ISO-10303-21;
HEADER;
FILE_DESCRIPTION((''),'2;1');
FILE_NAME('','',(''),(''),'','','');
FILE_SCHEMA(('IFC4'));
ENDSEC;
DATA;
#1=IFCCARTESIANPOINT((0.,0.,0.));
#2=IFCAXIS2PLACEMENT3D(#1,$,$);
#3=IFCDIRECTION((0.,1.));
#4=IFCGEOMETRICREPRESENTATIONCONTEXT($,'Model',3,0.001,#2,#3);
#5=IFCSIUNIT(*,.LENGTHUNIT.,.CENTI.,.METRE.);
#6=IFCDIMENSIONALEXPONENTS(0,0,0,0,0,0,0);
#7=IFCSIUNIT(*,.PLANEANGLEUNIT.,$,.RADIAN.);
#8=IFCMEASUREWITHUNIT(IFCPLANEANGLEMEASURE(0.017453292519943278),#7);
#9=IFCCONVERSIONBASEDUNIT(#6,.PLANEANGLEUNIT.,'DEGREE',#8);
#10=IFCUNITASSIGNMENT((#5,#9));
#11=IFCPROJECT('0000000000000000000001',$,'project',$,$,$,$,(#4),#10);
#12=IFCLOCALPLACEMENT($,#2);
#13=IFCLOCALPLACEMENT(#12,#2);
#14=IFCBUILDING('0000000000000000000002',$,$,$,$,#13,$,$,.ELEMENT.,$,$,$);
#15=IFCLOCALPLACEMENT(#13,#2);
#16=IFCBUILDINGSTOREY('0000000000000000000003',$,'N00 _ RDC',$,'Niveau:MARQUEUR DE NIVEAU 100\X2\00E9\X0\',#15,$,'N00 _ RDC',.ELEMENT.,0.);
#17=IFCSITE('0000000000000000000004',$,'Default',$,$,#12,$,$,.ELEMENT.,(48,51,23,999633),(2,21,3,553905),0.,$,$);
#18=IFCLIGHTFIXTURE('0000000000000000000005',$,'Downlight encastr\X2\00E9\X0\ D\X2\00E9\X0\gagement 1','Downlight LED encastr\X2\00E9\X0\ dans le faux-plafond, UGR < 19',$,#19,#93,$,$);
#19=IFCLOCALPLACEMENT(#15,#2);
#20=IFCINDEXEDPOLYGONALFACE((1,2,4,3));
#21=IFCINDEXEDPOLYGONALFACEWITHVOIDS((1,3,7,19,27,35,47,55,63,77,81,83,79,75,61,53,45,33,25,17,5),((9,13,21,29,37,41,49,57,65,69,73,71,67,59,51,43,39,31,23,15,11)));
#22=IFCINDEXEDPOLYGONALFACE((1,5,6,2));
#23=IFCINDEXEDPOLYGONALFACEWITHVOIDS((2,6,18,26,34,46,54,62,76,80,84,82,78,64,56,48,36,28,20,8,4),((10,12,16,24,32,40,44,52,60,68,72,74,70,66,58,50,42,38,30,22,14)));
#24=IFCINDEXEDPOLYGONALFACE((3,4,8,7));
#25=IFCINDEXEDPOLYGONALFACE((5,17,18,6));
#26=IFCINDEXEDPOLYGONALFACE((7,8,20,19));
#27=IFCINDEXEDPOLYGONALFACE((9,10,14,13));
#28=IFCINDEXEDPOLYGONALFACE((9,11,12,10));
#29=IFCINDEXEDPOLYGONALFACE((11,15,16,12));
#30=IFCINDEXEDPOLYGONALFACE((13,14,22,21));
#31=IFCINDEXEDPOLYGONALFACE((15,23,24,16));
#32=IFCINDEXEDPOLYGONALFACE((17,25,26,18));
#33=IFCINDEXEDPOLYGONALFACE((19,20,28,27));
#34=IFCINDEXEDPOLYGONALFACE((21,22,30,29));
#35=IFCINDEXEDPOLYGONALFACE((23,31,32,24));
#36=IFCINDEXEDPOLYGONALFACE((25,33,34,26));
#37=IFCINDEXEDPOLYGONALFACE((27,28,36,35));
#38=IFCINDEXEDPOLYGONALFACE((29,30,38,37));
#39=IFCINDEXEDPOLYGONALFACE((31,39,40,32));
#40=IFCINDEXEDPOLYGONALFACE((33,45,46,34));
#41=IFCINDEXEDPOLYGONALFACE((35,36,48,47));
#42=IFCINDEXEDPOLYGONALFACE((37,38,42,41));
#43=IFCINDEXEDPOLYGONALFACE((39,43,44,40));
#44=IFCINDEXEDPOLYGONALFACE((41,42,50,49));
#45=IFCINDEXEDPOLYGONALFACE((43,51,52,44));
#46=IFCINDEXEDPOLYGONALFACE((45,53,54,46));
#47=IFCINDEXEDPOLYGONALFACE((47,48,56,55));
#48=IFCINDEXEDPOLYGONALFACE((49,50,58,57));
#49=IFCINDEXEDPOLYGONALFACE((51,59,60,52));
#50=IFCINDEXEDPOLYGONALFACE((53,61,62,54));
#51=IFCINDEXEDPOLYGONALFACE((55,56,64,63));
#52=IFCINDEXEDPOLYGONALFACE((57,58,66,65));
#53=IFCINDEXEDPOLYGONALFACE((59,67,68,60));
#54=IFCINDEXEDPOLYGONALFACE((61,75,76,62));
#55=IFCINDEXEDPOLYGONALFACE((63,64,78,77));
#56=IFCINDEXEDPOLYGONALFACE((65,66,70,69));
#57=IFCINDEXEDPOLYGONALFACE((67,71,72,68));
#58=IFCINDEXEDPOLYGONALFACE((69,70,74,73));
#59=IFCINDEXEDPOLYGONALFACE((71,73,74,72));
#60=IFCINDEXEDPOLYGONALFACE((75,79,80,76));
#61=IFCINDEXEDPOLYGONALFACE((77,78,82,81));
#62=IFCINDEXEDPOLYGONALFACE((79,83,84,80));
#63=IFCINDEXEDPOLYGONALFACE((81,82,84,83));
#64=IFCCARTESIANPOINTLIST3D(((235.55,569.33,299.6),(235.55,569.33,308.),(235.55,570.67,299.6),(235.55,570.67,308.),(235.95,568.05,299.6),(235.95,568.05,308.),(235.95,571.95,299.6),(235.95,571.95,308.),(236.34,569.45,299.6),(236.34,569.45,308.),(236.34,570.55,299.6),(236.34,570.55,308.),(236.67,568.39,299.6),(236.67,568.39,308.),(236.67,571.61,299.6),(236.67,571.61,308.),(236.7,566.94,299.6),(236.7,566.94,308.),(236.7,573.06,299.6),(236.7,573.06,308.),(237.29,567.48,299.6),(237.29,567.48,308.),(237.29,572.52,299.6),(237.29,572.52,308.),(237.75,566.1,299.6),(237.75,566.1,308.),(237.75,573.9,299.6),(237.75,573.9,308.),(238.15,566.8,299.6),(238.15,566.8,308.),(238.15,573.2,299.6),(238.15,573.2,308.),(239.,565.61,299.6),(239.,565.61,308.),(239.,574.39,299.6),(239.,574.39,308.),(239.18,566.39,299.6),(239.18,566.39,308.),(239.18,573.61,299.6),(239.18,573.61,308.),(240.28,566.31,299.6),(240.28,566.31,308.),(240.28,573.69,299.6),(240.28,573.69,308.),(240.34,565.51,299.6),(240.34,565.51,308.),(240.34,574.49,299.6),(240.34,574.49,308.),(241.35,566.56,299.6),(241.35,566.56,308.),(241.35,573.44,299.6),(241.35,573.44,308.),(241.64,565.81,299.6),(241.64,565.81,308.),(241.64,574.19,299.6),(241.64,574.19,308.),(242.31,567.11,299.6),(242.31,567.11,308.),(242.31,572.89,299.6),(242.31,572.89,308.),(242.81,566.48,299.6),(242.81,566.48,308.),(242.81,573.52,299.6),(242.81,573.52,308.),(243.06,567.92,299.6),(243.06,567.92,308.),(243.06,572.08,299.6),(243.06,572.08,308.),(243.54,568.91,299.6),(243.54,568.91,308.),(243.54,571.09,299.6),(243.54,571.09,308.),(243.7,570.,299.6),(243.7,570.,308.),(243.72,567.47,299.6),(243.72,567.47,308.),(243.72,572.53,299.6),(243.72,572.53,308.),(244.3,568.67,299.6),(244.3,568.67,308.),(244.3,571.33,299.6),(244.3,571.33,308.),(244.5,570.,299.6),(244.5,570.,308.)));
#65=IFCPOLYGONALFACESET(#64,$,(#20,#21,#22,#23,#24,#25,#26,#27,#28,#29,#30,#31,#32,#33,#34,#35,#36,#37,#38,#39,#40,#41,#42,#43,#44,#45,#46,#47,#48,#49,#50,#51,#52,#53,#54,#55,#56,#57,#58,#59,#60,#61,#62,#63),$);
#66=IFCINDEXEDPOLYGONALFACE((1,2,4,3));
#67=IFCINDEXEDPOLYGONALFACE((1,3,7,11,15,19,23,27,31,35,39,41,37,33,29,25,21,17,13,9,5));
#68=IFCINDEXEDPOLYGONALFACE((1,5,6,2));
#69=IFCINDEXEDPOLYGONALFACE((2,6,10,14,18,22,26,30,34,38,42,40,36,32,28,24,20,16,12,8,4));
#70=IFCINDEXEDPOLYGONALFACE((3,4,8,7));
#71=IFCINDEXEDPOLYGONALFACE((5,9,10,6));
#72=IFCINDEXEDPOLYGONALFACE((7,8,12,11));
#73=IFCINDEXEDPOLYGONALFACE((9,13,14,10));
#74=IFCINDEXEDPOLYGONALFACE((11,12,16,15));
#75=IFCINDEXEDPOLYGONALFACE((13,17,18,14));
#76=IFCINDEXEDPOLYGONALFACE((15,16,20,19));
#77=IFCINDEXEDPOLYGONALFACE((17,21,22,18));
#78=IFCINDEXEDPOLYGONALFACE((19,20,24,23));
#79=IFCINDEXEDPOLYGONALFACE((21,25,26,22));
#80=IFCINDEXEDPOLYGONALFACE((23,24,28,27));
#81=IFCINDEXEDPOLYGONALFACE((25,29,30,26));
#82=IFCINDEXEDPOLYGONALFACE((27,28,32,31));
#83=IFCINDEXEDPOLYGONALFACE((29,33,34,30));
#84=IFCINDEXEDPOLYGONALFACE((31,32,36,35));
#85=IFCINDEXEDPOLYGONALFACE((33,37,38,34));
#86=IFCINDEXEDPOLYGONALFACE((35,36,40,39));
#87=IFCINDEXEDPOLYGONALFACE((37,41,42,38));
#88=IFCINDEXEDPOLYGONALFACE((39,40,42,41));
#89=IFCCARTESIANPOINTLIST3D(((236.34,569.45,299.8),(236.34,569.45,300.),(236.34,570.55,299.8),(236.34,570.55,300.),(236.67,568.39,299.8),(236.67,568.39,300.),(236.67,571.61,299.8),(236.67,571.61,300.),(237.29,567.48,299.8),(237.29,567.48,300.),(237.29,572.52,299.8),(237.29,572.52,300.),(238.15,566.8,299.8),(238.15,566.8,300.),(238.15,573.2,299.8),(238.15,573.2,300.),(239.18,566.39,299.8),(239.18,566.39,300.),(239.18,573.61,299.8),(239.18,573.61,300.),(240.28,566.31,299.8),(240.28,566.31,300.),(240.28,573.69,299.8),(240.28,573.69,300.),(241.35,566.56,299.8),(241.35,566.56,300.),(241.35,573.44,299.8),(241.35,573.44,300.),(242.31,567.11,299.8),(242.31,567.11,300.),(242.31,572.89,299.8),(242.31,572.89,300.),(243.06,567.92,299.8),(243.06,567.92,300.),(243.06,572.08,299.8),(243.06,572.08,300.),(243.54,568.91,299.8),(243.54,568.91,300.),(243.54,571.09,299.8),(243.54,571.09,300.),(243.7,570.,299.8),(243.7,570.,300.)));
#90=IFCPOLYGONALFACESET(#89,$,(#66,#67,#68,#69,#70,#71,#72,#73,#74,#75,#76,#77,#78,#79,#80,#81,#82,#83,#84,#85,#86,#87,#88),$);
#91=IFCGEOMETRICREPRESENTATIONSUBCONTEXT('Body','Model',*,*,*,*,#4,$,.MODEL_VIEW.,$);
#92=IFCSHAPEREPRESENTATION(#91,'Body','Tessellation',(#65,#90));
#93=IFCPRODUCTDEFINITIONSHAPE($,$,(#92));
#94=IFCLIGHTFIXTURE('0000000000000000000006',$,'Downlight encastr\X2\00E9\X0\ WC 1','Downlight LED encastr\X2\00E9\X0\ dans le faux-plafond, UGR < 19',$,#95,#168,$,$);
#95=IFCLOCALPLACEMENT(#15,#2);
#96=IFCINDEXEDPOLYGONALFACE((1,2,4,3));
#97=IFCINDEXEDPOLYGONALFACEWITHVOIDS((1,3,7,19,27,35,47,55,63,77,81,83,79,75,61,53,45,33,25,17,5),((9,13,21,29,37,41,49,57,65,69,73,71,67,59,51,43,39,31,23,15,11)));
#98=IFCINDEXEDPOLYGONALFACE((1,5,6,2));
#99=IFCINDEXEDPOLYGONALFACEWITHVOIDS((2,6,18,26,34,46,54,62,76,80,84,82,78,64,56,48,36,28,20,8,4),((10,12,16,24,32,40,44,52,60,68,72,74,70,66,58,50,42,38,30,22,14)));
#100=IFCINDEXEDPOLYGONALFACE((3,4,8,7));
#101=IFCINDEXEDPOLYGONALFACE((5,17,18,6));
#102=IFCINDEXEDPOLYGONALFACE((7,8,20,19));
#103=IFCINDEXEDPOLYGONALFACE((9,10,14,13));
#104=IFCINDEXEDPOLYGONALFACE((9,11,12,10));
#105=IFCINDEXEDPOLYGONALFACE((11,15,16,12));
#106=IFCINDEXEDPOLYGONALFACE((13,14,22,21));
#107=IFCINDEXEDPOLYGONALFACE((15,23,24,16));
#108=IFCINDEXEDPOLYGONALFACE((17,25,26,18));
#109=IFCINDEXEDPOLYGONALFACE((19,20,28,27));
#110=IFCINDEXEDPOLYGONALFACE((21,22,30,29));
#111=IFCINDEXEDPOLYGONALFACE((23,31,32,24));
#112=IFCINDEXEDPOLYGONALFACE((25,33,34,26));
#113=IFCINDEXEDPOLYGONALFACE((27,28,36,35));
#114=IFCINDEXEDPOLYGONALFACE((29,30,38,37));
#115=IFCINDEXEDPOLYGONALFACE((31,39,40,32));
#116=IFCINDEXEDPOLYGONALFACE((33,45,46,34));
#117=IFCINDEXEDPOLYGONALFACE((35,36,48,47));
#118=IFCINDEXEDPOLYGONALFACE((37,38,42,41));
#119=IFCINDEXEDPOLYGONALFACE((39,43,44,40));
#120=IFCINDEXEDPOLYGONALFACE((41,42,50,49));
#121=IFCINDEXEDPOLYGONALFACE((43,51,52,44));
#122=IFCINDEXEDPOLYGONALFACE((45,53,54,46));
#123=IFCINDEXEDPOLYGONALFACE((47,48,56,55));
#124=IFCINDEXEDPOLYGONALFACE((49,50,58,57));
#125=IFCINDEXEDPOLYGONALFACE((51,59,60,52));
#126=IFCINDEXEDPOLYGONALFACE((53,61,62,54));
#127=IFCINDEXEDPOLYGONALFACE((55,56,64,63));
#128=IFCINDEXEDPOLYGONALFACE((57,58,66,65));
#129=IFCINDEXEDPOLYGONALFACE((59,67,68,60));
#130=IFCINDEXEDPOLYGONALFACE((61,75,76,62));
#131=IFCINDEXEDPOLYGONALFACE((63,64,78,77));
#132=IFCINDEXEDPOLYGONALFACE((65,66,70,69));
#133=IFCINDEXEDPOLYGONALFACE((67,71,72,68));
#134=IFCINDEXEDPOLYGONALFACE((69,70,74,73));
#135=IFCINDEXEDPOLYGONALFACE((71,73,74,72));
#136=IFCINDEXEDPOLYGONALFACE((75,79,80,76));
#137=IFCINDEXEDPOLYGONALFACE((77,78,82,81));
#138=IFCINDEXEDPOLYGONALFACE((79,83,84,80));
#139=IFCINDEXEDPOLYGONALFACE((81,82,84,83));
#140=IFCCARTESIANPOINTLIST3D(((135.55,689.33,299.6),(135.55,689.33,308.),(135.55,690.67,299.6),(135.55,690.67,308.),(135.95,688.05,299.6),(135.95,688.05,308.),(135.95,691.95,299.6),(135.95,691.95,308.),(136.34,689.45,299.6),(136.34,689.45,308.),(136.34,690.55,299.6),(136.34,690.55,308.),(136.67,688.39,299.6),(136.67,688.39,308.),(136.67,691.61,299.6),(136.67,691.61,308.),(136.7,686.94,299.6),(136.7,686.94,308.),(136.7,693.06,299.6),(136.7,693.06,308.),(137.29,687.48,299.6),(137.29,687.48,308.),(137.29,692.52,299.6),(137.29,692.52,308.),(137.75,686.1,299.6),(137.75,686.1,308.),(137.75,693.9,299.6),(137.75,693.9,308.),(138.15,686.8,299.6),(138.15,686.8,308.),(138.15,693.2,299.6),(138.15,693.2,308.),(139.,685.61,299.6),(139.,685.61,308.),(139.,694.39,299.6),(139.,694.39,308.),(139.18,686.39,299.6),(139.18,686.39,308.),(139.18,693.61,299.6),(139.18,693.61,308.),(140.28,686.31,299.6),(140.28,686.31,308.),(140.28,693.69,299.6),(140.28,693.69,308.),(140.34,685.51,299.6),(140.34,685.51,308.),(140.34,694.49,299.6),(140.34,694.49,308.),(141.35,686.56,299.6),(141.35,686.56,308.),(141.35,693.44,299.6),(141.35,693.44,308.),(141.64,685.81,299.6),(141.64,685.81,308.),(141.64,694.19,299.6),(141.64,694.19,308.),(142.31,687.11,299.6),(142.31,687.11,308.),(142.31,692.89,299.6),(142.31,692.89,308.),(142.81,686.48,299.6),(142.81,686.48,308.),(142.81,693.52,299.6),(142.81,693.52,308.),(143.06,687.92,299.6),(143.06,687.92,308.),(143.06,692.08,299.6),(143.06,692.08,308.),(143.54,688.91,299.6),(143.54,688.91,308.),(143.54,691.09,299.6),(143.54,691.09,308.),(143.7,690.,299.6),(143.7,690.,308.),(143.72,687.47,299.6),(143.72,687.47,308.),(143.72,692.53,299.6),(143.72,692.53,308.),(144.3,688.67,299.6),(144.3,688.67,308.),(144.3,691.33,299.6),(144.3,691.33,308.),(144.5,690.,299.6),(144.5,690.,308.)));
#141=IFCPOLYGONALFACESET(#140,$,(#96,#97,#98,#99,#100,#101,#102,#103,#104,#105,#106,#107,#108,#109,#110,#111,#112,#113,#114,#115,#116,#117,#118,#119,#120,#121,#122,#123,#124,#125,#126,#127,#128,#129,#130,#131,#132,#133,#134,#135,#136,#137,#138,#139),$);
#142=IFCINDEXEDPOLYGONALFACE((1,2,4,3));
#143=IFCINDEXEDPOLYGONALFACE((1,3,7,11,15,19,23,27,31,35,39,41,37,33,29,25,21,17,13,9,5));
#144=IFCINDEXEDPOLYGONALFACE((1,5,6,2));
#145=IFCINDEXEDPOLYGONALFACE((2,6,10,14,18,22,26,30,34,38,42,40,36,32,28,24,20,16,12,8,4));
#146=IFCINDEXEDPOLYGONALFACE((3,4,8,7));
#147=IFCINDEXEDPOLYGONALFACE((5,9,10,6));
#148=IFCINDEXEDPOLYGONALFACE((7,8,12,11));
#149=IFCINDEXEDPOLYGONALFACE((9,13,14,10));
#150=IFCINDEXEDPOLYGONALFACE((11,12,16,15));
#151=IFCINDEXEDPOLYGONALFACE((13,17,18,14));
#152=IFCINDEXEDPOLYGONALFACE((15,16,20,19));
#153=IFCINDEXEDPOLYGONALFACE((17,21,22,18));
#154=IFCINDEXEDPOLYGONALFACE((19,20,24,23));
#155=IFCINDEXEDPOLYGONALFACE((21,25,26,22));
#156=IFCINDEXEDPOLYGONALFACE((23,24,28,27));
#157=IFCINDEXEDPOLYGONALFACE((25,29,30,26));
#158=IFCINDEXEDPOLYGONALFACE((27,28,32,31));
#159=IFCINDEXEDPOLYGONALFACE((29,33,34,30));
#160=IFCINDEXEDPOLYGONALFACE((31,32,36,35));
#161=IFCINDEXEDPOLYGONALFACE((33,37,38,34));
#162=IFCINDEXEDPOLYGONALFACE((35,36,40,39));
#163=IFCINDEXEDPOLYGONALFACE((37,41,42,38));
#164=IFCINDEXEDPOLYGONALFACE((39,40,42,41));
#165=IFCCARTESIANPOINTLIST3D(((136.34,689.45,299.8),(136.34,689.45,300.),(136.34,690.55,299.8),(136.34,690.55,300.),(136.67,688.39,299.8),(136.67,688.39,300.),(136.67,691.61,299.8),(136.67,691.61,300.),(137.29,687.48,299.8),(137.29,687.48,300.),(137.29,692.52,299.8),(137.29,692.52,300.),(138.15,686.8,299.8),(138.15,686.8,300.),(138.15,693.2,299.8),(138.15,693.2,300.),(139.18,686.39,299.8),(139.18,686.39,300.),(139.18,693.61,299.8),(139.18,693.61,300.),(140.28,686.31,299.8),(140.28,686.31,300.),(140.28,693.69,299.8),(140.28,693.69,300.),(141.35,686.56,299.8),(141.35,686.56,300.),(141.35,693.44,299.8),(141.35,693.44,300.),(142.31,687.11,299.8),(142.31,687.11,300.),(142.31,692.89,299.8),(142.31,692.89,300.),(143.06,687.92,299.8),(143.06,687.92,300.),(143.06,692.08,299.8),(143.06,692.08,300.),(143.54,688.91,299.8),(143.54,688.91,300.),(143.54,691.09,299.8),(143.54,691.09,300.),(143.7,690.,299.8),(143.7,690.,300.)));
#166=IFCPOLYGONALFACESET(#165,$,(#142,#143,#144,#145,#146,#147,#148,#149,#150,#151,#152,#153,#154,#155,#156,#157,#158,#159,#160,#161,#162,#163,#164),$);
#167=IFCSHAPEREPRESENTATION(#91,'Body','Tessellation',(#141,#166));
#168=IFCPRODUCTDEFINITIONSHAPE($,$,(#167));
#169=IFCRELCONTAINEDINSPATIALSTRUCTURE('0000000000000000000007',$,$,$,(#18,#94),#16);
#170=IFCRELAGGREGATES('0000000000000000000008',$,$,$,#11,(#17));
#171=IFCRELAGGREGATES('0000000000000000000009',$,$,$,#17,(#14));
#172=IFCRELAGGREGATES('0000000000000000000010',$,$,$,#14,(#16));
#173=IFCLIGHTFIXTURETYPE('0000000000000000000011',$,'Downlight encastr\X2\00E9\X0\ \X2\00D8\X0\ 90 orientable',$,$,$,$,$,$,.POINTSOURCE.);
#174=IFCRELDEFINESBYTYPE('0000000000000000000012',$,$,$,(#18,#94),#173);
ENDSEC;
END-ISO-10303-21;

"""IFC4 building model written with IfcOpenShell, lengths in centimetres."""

from ifc_helpers import new_model, entity, si_unit, converted_unit, direction, frame, frame_2d, origin, origin_with_axes, place, context, subcontext, project, spatial, circle, hollow_circle, extrude, type_object, element, save


model = new_model("IFC4")

# Units and contexts
model_context = context("Model", 3, precision=0.001, world=origin(), true_north=direction((0.0, 1.0)))
body_context = subcontext(model_context, "Body", "Model", "MODEL_VIEW")
ifc_project = project(units=[si_unit("LENGTHUNIT", "METRE", prefix="CENTI"), converted_unit("PLANEANGLEUNIT", "DEGREE", entity("IfcPlaneAngleMeasure", 0.017453292519943278), si_unit("PLANEANGLEUNIT", "RADIAN"), dimensions=[0, 0, 0, 0, 0, 0, 0])], contexts=[model_context])

# Site, building, storey
site_placement = place(None, origin())
site = spatial("IfcSite", under=ifc_project, at=site_placement, Name="Default", CompositionType="ELEMENT", RefLatitude=(48, 51, 23, 999633), RefLongitude=(2, 21, 3, 553905), RefElevation=0.0)
building_placement = place(site_placement, origin())
building = spatial("IfcBuilding", under=site, at=building_placement, CompositionType="ELEMENT")
storey_placement = place(building_placement, origin())
storey = spatial("IfcBuildingStorey", under=building, at=storey_placement, Name="N00 _ RDC", ObjectType="Niveau:MARQUEUR DE NIVEAU 100é", LongName="N00 _ RDC", CompositionType="ELEMENT", Elevation=0.0)

# Light fixtures
light_fixture_type_1 = type_object("IfcLightFixtureType", Name="Downlight encastré Ø 90 orientable", PredefinedType="POINTSOURCE")
light_fixture_1_placement = place(storey_placement, origin_with_axes())
element("IfcLightFixture", 1, at=light_fixture_1_placement, inside=storey, type_object=light_fixture_type_1, Name="Downlight encastré Dégagement 1", Description="Downlight LED encastré dans le faux-plafond, UGR < 19", context=body_context, shape_type="SweptSolid", body=[
    extrude(hollow_circle(Radius=4.5, WallThickness=0.8, at=frame_2d((240.0, 570.0))), frame((0.0, 0.0, 299.6)), (0.0, 0.0, 1.0), 8.4),
    extrude(circle(Radius=3.7, at=frame_2d((240.0, 570.0))), frame((0.0, 0.0, 299.8)), (0.0, 0.0, 1.0), 0.2),
])
light_fixture_2_placement = place(storey_placement, origin_with_axes())
element("IfcLightFixture", 2, at=light_fixture_2_placement, inside=storey, type_object=light_fixture_type_1, Name="Downlight encastré WC 1", Description="Downlight LED encastré dans le faux-plafond, UGR < 19", context=body_context, shape_type="SweptSolid", body=[
    extrude(hollow_circle(Radius=4.5, WallThickness=0.8, at=frame_2d((140.0, 690.0))), frame((0.0, 0.0, 299.6)), (0.0, 0.0, 1.0), 8.4),
    extrude(circle(Radius=3.7, at=frame_2d((140.0, 690.0))), frame((0.0, 0.0, 299.8)), (0.0, 0.0, 1.0), 0.2),
])

save(model, "model.ifc")
